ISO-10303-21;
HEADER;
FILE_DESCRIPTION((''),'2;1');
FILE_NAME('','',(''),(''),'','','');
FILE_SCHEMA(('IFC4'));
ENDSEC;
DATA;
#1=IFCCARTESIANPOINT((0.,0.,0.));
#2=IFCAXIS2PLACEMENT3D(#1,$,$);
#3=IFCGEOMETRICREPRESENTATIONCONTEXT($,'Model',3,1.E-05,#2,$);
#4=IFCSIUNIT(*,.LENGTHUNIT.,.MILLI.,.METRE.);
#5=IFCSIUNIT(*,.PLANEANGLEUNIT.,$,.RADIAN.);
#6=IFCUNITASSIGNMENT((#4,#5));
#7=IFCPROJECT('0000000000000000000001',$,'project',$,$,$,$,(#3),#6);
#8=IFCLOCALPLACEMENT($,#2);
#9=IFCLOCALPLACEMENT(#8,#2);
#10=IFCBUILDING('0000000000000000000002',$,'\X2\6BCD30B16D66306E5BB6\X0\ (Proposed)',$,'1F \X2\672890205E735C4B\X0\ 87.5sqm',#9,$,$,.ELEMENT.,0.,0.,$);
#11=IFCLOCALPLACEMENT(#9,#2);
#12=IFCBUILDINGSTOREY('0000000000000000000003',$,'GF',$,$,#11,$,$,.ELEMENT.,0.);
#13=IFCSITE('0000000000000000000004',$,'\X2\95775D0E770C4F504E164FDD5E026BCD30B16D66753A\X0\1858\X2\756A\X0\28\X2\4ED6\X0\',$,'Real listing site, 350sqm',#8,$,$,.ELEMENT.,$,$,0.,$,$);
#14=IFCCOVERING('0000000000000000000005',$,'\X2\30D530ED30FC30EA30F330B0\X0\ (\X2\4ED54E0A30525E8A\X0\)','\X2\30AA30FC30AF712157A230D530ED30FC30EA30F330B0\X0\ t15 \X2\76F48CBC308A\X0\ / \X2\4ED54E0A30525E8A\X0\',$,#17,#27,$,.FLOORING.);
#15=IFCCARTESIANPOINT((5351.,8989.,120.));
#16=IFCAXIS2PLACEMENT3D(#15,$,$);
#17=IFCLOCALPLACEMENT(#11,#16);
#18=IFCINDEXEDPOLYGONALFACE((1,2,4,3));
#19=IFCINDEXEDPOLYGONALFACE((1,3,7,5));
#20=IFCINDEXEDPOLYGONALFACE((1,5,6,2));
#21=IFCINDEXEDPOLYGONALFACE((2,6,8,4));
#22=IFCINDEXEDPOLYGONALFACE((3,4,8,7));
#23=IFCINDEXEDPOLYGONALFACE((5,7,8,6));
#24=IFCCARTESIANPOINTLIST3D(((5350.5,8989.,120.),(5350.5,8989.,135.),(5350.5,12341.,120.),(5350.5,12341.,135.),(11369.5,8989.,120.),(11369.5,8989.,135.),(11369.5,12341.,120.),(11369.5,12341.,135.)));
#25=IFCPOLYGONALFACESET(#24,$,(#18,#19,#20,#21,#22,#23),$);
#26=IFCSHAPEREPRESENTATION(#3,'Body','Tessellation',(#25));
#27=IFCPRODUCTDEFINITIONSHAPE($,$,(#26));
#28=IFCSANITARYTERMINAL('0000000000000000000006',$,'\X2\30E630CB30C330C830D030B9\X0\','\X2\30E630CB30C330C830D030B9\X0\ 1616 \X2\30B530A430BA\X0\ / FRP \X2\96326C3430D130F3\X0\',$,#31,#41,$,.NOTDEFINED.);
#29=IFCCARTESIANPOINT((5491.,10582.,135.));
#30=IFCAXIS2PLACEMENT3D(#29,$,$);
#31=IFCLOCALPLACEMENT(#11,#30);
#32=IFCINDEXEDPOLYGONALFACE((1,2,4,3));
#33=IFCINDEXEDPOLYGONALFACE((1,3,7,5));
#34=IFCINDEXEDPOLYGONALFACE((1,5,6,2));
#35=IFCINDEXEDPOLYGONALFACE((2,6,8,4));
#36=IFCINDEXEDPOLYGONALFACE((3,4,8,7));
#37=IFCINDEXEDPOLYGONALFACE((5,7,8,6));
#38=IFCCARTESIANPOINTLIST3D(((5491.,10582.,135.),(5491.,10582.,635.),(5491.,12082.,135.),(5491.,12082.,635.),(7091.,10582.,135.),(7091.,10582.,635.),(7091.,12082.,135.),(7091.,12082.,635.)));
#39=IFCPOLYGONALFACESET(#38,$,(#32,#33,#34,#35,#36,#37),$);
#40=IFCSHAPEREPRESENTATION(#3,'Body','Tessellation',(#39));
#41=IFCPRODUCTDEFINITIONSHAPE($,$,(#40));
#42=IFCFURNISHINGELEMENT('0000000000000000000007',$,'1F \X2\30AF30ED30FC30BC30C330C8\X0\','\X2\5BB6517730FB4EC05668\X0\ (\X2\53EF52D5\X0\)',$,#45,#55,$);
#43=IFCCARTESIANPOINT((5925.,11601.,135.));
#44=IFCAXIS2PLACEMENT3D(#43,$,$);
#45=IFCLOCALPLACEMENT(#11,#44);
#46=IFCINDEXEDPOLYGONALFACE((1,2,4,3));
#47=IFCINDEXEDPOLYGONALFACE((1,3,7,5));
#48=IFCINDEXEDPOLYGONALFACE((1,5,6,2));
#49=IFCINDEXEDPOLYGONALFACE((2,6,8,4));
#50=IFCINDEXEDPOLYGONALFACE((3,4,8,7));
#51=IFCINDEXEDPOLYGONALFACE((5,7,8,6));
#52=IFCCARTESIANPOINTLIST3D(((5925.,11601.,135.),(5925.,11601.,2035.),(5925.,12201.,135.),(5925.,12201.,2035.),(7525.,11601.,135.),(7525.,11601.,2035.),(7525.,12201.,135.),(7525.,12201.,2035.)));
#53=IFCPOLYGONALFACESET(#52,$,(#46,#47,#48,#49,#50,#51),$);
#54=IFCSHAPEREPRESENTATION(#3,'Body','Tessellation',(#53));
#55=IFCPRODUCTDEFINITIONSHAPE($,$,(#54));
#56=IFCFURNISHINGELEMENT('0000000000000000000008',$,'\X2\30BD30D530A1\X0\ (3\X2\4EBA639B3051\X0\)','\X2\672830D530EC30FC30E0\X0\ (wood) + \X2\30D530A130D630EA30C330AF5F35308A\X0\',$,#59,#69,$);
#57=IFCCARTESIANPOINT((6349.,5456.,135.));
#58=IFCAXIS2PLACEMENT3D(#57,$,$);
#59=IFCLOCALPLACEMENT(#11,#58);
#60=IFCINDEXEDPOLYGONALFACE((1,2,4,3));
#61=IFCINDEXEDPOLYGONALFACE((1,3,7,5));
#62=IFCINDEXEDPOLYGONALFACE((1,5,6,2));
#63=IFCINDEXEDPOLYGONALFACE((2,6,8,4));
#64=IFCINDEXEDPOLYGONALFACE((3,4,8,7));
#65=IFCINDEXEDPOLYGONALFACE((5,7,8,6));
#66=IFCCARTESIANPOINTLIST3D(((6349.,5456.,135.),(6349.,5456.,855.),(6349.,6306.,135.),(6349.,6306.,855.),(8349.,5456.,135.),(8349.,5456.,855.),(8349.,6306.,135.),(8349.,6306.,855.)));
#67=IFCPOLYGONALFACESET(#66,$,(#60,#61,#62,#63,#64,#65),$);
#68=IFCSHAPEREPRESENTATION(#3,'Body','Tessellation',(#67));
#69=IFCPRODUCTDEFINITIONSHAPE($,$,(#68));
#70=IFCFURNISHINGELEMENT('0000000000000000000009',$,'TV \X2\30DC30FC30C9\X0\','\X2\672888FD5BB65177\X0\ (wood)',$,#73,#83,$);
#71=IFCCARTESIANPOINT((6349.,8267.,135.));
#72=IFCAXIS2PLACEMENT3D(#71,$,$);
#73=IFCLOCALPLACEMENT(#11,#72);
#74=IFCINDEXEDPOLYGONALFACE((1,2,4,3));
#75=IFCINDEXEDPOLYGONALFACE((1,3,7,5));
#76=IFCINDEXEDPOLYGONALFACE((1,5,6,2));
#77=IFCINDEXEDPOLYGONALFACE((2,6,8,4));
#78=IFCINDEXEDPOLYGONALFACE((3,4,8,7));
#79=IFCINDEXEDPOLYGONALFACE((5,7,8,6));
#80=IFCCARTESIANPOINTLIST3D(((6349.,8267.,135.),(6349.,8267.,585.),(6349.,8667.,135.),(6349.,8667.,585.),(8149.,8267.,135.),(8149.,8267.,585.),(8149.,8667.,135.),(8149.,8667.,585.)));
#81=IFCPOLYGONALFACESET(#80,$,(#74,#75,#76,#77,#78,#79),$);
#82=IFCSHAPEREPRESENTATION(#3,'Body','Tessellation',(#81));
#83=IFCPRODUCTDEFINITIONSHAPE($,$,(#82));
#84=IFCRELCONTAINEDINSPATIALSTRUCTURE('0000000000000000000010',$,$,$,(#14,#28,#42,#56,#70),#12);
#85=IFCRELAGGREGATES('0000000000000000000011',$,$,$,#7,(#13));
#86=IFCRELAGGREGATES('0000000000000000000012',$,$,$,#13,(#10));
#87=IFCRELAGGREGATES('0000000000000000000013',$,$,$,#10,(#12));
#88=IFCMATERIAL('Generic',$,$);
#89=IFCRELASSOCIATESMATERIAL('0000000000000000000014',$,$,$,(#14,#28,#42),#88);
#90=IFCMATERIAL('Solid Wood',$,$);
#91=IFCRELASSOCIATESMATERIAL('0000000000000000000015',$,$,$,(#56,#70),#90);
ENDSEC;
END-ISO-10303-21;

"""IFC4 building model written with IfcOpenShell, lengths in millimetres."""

from ifc_helpers import new_model, si_unit, frame, frame_2d, origin, place, context, project, spatial, rectangle, extrude, material, element, save


model = new_model("IFC4")

# Units and contexts
model_context = context("Model", 3, precision=1e-05, world=origin())
ifc_project = project(units=[si_unit("LENGTHUNIT", "METRE", prefix="MILLI"), si_unit("PLANEANGLEUNIT", "RADIAN")], contexts=[model_context])

# Site, building, storey
site_placement = place(None, origin())
site = spatial("IfcSite", under=ifc_project, at=site_placement, Name="長崎県佐世保市母ケ浦町1858番28他", ObjectType="Real listing site, 350sqm", CompositionType="ELEMENT", RefElevation=0.0)
building_placement = place(site_placement, origin())
building = spatial("IfcBuilding", under=site, at=building_placement, Name="母ケ浦の家 (Proposed)", ObjectType="1F 木造平屋 87.5sqm", CompositionType="ELEMENT", ElevationOfRefHeight=0.0, ElevationOfTerrain=0.0)
storey_placement = place(building_placement, origin())
storey = spatial("IfcBuildingStorey", under=building, at=storey_placement, Name="GF", CompositionType="ELEMENT", Elevation=0.0)

# Shared definitions
ifc_material_1 = material(Name="Solid Wood")

# Covering
ifc_material_2 = material(Name="Generic")
covering_1_placement = place(storey_placement, frame((5351.0, 8989.0, 120.0)))
element("IfcCovering", 1, at=covering_1_placement, inside=storey, material=ifc_material_2, Name="フローリング (仕上げ床)", Description="オーク無垢フローリング t15 直貼り / 仕上げ床", PredefinedType="FLOORING", context=model_context, shape_type="SweptSolid", body=[
    extrude(rectangle(XDim=6019.0, YDim=3352.0, at=frame_2d((3009.0, 1676.0))), frame((5351.0, 8989.0, 120.0)), (0.0, 0.0, 1.0), 15.0),
])

# Sanitary terminal
sanitary_terminal_placement = place(storey_placement, frame((5491.0, 10582.0, 135.0)))
element("IfcSanitaryTerminal", 2, at=sanitary_terminal_placement, inside=storey, material=ifc_material_2, Name="ユニットバス", Description="ユニットバス 1616 サイズ / FRP 防水パン", PredefinedType="NOTDEFINED", context=model_context, shape_type="SweptSolid", body=[
    extrude(rectangle(XDim=1600.0, YDim=1500.0, at=frame_2d((800.0, 750.0))), frame((5491.0, 10582.0, 135.0)), (0.0, 0.0, 1.0), 500.0),
])

# Furnishing elements
furnishing_1_placement = place(storey_placement, frame((5925.0, 11601.0, 135.0)))
element("IfcFurnishingElement", 3, at=furnishing_1_placement, inside=storey, material=ifc_material_2, Name="1F クローゼット", Description="家具・什器 (可動)", context=model_context, shape_type="SweptSolid", body=[
    extrude(rectangle(XDim=1600.0, YDim=600.0, at=frame_2d((800.0, 300.0))), frame((5925.0, 11601.0, 135.0)), (0.0, 0.0, 1.0), 1900.0),
])
furnishing_2_placement = place(storey_placement, frame((6349.0, 5456.0, 135.0)))
element("IfcFurnishingElement", 4, at=furnishing_2_placement, inside=storey, material=ifc_material_1, Name="ソファ (3人掛け)", Description="木フレーム (wood) + ファブリック張り", context=model_context, shape_type="SweptSolid", body=[
    extrude(rectangle(XDim=2000.0, YDim=850.0, at=frame_2d((1000.0, 425.0))), frame((6349.0, 5456.0, 135.0)), (0.0, 0.0, 1.0), 720.0),
])
furnishing_3_placement = place(storey_placement, frame((6349.0, 8267.0, 135.0)))
element("IfcFurnishingElement", 5, at=furnishing_3_placement, inside=storey, material=ifc_material_1, Name="TV ボード", Description="木製家具 (wood)", context=model_context, shape_type="SweptSolid", body=[
    extrude(rectangle(XDim=1800.0, YDim=400.0, at=frame_2d((900.0, 200.0))), frame((6349.0, 8267.0, 135.0)), (0.0, 0.0, 1.0), 450.0),
])

save(model, "model.ifc")
